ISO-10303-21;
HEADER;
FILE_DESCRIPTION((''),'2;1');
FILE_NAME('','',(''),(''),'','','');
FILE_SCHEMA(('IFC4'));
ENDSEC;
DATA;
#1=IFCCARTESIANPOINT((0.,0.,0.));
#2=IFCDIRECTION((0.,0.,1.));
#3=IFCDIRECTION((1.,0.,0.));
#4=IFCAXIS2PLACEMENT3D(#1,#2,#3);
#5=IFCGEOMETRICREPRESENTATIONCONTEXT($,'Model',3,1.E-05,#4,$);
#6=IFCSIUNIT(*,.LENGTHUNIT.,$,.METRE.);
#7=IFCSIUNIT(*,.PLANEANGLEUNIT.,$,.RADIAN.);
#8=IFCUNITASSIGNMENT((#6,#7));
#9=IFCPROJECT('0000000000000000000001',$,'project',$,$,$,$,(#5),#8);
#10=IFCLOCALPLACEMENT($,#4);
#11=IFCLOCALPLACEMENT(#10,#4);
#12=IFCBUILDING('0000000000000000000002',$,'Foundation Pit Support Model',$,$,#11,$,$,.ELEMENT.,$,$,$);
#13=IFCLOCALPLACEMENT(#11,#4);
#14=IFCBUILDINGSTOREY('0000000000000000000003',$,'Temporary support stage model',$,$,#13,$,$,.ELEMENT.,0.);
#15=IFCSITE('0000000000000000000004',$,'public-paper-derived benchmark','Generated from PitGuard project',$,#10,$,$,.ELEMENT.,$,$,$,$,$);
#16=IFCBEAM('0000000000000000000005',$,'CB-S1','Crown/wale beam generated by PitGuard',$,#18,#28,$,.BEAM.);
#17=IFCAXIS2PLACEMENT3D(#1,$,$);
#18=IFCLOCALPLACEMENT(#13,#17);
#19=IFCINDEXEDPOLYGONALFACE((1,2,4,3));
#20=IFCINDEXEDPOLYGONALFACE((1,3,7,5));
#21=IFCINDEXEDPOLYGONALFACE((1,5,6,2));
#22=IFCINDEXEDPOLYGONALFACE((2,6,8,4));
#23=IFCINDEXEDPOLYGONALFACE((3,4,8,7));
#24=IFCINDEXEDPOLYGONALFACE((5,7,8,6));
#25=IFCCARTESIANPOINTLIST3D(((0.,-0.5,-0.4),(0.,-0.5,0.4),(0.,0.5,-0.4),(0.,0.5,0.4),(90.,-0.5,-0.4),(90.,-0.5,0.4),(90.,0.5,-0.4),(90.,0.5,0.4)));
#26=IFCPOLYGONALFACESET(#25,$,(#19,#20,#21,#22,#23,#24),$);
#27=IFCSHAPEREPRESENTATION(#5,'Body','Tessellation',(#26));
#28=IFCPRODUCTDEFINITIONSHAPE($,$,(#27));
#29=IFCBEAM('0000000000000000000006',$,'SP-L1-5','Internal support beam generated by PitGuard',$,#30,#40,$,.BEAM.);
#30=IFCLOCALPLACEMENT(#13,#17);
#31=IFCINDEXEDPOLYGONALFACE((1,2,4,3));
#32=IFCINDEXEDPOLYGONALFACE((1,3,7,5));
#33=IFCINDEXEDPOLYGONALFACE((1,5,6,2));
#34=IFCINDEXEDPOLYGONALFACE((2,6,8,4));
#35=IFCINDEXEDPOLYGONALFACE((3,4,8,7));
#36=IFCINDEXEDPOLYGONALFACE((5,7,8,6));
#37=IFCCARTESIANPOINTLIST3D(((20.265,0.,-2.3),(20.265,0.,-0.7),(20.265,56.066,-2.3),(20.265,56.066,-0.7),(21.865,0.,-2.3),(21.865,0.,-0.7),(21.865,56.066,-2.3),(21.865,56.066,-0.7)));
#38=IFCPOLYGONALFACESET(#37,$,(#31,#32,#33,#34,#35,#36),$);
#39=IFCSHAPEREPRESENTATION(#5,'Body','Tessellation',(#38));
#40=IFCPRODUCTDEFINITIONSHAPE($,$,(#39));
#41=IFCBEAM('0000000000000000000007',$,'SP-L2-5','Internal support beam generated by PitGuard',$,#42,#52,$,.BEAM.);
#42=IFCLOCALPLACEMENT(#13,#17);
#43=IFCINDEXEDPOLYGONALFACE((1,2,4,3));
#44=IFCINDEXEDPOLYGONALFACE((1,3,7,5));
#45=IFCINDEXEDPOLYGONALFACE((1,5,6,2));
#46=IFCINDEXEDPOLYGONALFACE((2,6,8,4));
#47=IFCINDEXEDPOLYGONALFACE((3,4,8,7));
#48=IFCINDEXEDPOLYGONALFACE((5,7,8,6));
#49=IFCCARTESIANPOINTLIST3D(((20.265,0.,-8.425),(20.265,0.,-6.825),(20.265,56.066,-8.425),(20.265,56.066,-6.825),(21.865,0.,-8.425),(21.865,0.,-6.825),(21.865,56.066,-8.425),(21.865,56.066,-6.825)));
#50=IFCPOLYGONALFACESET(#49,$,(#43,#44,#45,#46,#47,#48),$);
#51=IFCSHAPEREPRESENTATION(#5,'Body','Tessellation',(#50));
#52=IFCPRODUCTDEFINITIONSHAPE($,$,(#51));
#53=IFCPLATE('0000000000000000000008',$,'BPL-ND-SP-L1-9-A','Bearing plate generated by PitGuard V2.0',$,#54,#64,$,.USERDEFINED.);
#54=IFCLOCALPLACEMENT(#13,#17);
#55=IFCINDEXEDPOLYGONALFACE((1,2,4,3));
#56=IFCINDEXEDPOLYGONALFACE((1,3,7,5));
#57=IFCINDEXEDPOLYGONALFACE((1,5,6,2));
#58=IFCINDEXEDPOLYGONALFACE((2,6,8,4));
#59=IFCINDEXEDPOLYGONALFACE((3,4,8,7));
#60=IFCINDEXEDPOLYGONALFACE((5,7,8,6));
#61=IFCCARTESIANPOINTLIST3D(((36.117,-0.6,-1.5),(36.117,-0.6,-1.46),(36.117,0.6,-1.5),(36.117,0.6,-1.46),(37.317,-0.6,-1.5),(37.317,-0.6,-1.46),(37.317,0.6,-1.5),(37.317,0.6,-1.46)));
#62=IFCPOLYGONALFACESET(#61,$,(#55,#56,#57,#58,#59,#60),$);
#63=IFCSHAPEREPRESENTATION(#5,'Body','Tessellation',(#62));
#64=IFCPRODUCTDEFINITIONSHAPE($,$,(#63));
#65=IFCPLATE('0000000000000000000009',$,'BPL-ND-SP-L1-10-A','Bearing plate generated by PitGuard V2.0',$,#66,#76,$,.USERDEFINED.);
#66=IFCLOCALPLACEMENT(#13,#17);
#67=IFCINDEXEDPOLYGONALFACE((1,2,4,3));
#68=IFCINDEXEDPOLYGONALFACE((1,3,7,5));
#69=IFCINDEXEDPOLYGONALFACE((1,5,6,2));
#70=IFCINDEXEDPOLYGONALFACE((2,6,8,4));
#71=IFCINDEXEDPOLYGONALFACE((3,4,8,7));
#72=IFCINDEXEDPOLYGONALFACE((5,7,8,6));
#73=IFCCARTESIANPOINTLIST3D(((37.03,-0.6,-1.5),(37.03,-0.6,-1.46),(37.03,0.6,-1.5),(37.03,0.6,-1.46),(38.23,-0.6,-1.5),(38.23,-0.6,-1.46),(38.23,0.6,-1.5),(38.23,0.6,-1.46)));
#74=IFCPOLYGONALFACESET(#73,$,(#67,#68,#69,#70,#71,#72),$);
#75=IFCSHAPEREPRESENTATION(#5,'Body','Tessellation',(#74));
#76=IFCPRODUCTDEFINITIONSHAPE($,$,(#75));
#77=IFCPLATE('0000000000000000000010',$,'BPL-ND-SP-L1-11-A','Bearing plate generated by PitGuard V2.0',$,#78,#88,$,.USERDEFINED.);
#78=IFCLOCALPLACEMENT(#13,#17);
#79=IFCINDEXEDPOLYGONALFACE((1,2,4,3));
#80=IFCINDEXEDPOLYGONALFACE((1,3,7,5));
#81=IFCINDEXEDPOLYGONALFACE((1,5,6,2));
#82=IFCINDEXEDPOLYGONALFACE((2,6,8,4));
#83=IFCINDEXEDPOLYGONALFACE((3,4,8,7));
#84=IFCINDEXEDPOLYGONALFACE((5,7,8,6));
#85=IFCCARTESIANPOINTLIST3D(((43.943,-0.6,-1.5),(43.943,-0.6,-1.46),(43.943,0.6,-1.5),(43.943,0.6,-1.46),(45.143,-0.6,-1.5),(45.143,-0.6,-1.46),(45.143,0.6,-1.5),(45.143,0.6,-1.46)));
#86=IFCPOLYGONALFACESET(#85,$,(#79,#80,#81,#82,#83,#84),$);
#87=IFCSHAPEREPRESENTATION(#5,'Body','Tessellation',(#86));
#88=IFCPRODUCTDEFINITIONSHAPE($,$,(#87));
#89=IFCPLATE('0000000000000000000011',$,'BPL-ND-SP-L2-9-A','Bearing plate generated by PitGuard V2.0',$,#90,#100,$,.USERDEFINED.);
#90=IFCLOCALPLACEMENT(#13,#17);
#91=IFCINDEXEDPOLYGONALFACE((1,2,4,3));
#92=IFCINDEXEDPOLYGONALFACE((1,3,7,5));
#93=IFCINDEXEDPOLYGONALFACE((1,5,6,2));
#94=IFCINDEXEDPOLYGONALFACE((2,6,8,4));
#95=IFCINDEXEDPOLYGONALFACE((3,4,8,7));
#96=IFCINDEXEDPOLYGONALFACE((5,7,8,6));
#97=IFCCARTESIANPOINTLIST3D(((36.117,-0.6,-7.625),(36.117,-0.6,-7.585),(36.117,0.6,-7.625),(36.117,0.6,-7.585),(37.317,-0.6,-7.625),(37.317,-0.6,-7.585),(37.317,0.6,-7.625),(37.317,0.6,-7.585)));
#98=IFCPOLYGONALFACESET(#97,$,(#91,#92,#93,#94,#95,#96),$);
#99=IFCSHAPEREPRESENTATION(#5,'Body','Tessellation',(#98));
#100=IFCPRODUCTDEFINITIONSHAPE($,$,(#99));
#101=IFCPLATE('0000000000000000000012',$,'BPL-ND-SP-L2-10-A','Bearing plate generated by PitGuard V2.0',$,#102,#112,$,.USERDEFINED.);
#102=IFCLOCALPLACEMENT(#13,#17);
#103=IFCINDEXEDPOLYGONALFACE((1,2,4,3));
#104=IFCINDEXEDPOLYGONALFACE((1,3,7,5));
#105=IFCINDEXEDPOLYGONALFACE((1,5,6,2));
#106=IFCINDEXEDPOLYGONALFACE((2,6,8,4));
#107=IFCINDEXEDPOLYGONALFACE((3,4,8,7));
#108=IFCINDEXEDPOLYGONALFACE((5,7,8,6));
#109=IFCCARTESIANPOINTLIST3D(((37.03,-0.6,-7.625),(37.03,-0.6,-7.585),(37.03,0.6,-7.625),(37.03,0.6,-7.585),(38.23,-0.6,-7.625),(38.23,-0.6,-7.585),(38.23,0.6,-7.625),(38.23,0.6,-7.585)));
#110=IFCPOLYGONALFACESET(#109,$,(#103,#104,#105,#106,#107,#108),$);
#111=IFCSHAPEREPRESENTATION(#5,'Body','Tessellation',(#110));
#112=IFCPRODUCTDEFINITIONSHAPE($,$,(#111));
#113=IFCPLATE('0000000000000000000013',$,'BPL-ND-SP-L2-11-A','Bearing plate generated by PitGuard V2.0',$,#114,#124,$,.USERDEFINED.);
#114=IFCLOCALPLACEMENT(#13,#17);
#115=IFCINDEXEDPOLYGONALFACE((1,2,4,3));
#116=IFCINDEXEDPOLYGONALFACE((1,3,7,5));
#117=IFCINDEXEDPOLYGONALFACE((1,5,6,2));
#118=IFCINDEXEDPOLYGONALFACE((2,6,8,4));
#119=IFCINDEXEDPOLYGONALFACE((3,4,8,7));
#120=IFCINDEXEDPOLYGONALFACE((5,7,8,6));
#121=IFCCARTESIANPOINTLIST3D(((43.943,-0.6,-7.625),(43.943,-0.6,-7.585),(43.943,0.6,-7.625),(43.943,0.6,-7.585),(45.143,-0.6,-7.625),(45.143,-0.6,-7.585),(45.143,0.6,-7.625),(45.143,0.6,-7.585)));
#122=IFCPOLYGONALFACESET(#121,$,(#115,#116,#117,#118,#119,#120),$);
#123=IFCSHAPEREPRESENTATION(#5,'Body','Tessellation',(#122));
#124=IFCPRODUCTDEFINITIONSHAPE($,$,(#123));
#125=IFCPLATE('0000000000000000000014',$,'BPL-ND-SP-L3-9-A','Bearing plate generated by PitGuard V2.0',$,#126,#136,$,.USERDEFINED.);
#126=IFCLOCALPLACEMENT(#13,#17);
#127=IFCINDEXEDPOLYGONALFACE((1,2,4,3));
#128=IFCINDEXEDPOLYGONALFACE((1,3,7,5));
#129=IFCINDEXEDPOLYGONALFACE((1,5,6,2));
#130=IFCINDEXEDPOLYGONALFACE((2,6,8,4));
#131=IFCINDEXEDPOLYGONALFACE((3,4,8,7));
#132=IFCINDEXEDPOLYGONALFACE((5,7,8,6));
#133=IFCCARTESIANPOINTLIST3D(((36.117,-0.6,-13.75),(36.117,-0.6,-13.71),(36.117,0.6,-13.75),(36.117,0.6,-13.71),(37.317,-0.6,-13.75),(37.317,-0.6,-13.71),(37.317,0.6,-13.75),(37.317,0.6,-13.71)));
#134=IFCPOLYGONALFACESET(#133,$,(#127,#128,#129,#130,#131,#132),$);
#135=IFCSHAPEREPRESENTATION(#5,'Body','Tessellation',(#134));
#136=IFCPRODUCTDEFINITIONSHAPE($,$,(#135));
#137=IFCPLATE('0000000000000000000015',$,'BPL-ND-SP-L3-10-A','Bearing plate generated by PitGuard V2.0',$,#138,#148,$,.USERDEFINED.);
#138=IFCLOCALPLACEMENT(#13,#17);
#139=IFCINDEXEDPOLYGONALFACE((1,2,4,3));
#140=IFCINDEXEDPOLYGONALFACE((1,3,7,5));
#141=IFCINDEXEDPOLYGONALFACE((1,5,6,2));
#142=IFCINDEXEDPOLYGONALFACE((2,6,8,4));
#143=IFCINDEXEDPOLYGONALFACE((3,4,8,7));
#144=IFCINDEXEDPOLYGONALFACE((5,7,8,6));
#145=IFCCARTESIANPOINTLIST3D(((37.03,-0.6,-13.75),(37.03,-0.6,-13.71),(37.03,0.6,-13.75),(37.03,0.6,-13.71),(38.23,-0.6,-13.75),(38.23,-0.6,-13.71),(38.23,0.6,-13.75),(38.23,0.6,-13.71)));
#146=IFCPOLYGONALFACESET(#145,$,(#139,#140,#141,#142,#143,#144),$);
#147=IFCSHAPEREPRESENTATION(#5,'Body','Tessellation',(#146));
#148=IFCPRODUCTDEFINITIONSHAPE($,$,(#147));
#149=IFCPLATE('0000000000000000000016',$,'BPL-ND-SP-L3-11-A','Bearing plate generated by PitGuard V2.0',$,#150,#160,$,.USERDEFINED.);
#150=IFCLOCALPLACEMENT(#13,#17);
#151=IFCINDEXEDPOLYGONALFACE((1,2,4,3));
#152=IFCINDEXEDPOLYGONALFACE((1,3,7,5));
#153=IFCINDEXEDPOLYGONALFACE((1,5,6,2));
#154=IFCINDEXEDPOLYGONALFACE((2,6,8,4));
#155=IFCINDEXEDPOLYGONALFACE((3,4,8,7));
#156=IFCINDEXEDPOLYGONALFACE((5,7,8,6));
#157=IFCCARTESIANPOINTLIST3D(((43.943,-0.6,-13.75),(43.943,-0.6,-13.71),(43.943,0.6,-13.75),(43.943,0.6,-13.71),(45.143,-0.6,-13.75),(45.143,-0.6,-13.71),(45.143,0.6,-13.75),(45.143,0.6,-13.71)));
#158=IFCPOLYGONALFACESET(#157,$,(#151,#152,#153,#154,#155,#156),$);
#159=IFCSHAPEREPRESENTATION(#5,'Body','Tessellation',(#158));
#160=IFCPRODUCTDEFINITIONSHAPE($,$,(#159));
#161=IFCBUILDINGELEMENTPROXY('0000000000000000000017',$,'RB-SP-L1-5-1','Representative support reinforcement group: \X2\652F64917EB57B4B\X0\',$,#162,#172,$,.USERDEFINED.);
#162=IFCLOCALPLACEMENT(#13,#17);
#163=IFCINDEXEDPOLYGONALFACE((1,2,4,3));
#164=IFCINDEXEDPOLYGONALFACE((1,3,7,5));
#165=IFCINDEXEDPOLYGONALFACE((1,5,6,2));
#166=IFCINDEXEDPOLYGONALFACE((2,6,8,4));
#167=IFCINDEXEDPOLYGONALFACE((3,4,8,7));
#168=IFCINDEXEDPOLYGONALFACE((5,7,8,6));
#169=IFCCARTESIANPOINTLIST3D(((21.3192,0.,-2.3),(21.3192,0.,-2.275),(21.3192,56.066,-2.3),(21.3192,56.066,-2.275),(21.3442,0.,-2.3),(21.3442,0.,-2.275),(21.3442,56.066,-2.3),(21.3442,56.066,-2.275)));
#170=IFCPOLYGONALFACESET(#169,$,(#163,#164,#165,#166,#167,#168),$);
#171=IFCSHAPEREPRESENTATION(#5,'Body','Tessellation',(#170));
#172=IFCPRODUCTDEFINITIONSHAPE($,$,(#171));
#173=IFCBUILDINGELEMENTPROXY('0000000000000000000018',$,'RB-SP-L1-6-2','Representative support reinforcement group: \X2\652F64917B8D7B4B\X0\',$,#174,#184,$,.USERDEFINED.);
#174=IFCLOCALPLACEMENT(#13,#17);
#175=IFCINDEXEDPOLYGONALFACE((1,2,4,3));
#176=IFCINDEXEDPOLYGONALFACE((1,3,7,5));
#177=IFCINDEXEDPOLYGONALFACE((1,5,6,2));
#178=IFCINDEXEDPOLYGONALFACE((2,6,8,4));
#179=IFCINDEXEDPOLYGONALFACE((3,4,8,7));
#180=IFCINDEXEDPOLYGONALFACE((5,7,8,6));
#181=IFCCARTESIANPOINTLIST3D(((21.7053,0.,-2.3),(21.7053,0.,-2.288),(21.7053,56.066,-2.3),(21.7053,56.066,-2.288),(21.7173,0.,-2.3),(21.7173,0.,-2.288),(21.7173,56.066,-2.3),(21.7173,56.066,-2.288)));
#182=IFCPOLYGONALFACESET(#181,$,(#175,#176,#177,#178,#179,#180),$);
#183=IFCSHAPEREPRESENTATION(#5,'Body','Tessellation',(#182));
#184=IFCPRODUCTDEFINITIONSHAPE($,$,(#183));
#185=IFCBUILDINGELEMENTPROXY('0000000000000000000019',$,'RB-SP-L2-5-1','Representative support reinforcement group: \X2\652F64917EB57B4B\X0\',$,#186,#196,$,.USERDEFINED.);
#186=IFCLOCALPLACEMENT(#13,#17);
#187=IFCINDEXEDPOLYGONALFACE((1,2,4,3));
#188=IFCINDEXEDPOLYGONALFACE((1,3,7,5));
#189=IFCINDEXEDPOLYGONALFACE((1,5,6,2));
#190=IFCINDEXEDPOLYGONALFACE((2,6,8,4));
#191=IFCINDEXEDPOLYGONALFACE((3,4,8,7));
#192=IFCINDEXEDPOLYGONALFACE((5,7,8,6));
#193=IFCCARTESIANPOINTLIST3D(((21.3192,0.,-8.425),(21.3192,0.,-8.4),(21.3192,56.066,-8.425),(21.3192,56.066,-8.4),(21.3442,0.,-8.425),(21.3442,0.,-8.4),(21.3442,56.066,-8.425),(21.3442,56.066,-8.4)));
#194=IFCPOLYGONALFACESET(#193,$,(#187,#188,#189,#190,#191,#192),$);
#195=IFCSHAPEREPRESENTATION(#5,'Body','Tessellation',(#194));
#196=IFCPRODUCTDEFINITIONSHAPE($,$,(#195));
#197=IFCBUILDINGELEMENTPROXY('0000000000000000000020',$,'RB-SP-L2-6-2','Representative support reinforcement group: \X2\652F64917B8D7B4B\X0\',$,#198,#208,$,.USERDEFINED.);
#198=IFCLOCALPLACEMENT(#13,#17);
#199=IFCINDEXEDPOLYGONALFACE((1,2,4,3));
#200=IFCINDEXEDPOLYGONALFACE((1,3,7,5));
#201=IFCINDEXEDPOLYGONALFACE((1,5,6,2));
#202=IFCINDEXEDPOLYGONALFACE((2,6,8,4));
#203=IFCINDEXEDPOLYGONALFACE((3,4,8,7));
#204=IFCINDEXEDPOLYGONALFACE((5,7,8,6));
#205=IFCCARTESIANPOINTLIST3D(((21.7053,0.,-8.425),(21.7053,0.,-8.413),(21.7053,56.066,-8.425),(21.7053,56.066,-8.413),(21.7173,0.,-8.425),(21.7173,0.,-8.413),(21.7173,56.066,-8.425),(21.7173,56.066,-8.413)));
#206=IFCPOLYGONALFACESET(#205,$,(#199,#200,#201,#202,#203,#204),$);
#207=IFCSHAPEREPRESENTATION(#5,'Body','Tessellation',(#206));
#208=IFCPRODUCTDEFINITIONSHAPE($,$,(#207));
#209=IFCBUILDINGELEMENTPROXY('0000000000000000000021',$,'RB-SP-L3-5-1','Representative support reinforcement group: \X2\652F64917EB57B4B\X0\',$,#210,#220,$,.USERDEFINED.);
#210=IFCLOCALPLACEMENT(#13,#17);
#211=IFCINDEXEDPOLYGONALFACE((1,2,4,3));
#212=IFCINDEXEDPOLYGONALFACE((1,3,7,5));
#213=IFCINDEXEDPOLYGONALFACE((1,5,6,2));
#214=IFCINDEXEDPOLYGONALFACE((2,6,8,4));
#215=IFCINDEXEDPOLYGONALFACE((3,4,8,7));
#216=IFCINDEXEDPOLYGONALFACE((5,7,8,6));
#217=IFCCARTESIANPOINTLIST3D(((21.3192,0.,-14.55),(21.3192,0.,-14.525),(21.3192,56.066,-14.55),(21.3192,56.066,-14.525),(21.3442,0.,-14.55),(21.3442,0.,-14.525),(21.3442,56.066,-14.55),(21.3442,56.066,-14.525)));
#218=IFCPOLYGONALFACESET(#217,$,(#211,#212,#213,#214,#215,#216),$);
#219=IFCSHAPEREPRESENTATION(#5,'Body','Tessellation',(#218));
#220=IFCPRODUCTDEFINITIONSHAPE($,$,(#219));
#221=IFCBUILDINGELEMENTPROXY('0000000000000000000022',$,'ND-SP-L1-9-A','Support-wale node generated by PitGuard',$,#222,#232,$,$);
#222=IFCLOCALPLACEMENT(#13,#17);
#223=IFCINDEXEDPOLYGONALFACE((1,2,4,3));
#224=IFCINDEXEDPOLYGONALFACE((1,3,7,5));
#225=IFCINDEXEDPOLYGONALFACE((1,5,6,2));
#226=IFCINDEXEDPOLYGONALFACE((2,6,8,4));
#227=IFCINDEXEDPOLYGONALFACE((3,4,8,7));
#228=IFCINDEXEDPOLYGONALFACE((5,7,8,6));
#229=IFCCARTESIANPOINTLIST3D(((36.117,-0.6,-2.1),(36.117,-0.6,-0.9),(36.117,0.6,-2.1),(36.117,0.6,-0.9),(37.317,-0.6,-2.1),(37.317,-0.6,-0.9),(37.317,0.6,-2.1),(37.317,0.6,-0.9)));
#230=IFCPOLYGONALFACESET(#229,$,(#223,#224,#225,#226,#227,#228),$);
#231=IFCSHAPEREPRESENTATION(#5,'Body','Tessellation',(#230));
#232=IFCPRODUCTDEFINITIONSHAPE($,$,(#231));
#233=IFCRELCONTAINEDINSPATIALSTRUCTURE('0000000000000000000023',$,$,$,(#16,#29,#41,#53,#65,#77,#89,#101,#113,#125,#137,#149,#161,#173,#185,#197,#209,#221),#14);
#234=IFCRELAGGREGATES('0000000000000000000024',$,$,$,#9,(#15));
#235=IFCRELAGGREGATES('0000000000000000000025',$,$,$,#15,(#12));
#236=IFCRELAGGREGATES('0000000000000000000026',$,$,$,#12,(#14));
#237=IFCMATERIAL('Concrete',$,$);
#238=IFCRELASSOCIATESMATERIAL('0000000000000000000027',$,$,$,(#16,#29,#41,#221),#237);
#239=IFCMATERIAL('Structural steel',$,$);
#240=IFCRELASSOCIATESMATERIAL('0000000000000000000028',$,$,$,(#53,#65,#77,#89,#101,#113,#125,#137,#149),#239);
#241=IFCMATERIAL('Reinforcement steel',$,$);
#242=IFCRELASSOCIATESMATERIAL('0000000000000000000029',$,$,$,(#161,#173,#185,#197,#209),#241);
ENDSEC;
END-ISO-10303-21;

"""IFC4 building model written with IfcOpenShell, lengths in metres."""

from ifc_helpers import new_model, si_unit, frame, origin_with_axes, origin_2d, place, context, project, spatial, rectangle, extrude, material, element, save


model = new_model("IFC4")

# Units and contexts
model_context = context("Model", 3, precision=1e-05, world=origin_with_axes())
ifc_project = project(units=[si_unit("LENGTHUNIT", "METRE"), si_unit("PLANEANGLEUNIT", "RADIAN")], contexts=[model_context])

# Site, building, storey
site_placement = place(None, origin_with_axes())
site = spatial("IfcSite", under=ifc_project, at=site_placement, Name="public-paper-derived benchmark", Description="Generated from PitGuard project", CompositionType="ELEMENT")
building_placement = place(site_placement, origin_with_axes())
building = spatial("IfcBuilding", under=site, at=building_placement, Name="Foundation Pit Support Model", CompositionType="ELEMENT")
storey_placement = place(building_placement, origin_with_axes())
storey = spatial("IfcBuildingStorey", under=building, at=storey_placement, Name="Temporary support stage model", CompositionType="ELEMENT", Elevation=0.0)

# Beams
ifc_material_1 = material(Name="Concrete")
beam_placement = place(storey_placement, frame((45.0, 0.0, -0.4), z_axis=(0.0, 0.0, 1.0), x_axis=(1.0, 0.0, 0.0)))
element("IfcBeam", 1, at=beam_placement, inside=storey, material=ifc_material_1, Name="CB-S1", Description="Crown/wale beam generated by PitGuard", PredefinedType="BEAM", context=model_context, shape_type="SweptSolid", body=[
    extrude(rectangle(XDim=90.0, YDim=1.0, at=origin_2d()), origin_with_axes(), (0.0, 0.0, 1.0), 0.8),
])
for number, where, z_axis, x_axis, name in (
    (2, (21.065, 28.033, -2.3), (0.0, 0.0, 1.0), (0.0, 1.0, 0.0), "SP-L1-5"),
    (3, (21.065, 28.033, -8.425), (0.0, 0.0, 1.0), (0.0, 1.0, 0.0), "SP-L2-5"),
):
    element("IfcBeam", number, at=place(storey_placement, frame(where, z_axis=z_axis, x_axis=x_axis)), inside=storey, material=ifc_material_1, Name=name, Description="Internal support beam generated by PitGuard", PredefinedType="BEAM", context=model_context, shape_type="SweptSolid", body=[
        extrude(rectangle(XDim=56.066, YDim=1.6, at=origin_2d()), origin_with_axes(), (0.0, 0.0, 1.0), 1.6),
    ])

# Plates
ifc_material_2 = material(Name="Structural steel")
for number, where, z_axis, x_axis, name in (
    (4, (36.717, 0.0, -1.5), (0.0, 0.0, 1.0), (1.0, 0.0, 0.0), "BPL-ND-SP-L1-9-A"),
    (5, (37.63, 0.0, -1.5), (0.0, 0.0, 1.0), (1.0, 0.0, 0.0), "BPL-ND-SP-L1-10-A"),
    (6, (44.543, 0.0, -1.5), (0.0, 0.0, 1.0), (1.0, 0.0, 0.0), "BPL-ND-SP-L1-11-A"),
    (7, (36.717, 0.0, -7.625), (0.0, 0.0, 1.0), (1.0, 0.0, 0.0), "BPL-ND-SP-L2-9-A"),
    (8, (37.63, 0.0, -7.625), (0.0, 0.0, 1.0), (1.0, 0.0, 0.0), "BPL-ND-SP-L2-10-A"),
    (9, (44.543, 0.0, -7.625), (0.0, 0.0, 1.0), (1.0, 0.0, 0.0), "BPL-ND-SP-L2-11-A"),
    (10, (36.717, 0.0, -13.75), (0.0, 0.0, 1.0), (1.0, 0.0, 0.0), "BPL-ND-SP-L3-9-A"),
    (11, (37.63, 0.0, -13.75), (0.0, 0.0, 1.0), (1.0, 0.0, 0.0), "BPL-ND-SP-L3-10-A"),
    (12, (44.543, 0.0, -13.75), (0.0, 0.0, 1.0), (1.0, 0.0, 0.0), "BPL-ND-SP-L3-11-A"),
):
    element("IfcPlate", number, at=place(storey_placement, frame(where, z_axis=z_axis, x_axis=x_axis)), inside=storey, material=ifc_material_2, Name=name, Description="Bearing plate generated by PitGuard V2.0", PredefinedType="USERDEFINED", context=model_context, shape_type="SweptSolid", body=[
        extrude(rectangle(XDim=1.2, YDim=1.2, at=origin_2d()), origin_with_axes(), (0.0, 0.0, 1.0), 0.04),
    ])

# Building element proxies
ifc_material_3 = material(Name="Reinforcement steel")
proxy_1_placement = place(storey_placement, frame((21.3317, 28.033, -2.3), z_axis=(0.0, 0.0, 1.0), x_axis=(0.0, 1.0, 0.0)))
element("IfcBuildingElementProxy", 13, at=proxy_1_placement, inside=storey, material=ifc_material_3, Name="RB-SP-L1-5-1", Description="Representative support reinforcement group: 支撑纵筋", PredefinedType="USERDEFINED", context=model_context, shape_type="SweptSolid", body=[
    extrude(rectangle(XDim=56.066, YDim=0.025, at=origin_2d()), origin_with_axes(), (0.0, 0.0, 1.0), 0.025),
])
proxy_2_placement = place(storey_placement, frame((21.7113, 28.033, -2.3), z_axis=(0.0, 0.0, 1.0), x_axis=(0.0, 1.0, 0.0)))
element("IfcBuildingElementProxy", 14, at=proxy_2_placement, inside=storey, material=ifc_material_3, Name="RB-SP-L1-6-2", Description="Representative support reinforcement group: 支撑箍筋", PredefinedType="USERDEFINED", context=model_context, shape_type="SweptSolid", body=[
    extrude(rectangle(XDim=56.066, YDim=0.012, at=origin_2d()), origin_with_axes(), (0.0, 0.0, 1.0), 0.012),
])
proxy_3_placement = place(storey_placement, frame((21.3317, 28.033, -8.425), z_axis=(0.0, 0.0, 1.0), x_axis=(0.0, 1.0, 0.0)))
element("IfcBuildingElementProxy", 15, at=proxy_3_placement, inside=storey, material=ifc_material_3, Name="RB-SP-L2-5-1", Description="Representative support reinforcement group: 支撑纵筋", PredefinedType="USERDEFINED", context=model_context, shape_type="SweptSolid", body=[
    extrude(rectangle(XDim=56.066, YDim=0.025, at=origin_2d()), origin_with_axes(), (0.0, 0.0, 1.0), 0.025),
])
proxy_4_placement = place(storey_placement, frame((21.7113, 28.033, -8.425), z_axis=(0.0, 0.0, 1.0), x_axis=(0.0, 1.0, 0.0)))
element("IfcBuildingElementProxy", 16, at=proxy_4_placement, inside=storey, material=ifc_material_3, Name="RB-SP-L2-6-2", Description="Representative support reinforcement group: 支撑箍筋", PredefinedType="USERDEFINED", context=model_context, shape_type="SweptSolid", body=[
    extrude(rectangle(XDim=56.066, YDim=0.012, at=origin_2d()), origin_with_axes(), (0.0, 0.0, 1.0), 0.012),
])
proxy_5_placement = place(storey_placement, frame((21.3317, 28.033, -14.55), z_axis=(0.0, 0.0, 1.0), x_axis=(0.0, 1.0, 0.0)))
element("IfcBuildingElementProxy", 17, at=proxy_5_placement, inside=storey, material=ifc_material_3, Name="RB-SP-L3-5-1", Description="Representative support reinforcement group: 支撑纵筋", PredefinedType="USERDEFINED", context=model_context, shape_type="SweptSolid", body=[
    extrude(rectangle(XDim=56.066, YDim=0.025, at=origin_2d()), origin_with_axes(), (0.0, 0.0, 1.0), 0.025),
])
proxy_6_placement = place(storey_placement, frame((36.717, 0.0, -2.1), z_axis=(0.0, 0.0, 1.0), x_axis=(1.0, 0.0, 0.0)))
element("IfcBuildingElementProxy", 18, at=proxy_6_placement, inside=storey, material=ifc_material_1, Name="ND-SP-L1-9-A", Description="Support-wale node generated by PitGuard", context=model_context, shape_type="SweptSolid", body=[
    extrude(rectangle(XDim=1.2, YDim=1.2, at=origin_2d()), origin_with_axes(), (0.0, 0.0, 1.0), 1.2),
])

save(model, "model.ifc")
